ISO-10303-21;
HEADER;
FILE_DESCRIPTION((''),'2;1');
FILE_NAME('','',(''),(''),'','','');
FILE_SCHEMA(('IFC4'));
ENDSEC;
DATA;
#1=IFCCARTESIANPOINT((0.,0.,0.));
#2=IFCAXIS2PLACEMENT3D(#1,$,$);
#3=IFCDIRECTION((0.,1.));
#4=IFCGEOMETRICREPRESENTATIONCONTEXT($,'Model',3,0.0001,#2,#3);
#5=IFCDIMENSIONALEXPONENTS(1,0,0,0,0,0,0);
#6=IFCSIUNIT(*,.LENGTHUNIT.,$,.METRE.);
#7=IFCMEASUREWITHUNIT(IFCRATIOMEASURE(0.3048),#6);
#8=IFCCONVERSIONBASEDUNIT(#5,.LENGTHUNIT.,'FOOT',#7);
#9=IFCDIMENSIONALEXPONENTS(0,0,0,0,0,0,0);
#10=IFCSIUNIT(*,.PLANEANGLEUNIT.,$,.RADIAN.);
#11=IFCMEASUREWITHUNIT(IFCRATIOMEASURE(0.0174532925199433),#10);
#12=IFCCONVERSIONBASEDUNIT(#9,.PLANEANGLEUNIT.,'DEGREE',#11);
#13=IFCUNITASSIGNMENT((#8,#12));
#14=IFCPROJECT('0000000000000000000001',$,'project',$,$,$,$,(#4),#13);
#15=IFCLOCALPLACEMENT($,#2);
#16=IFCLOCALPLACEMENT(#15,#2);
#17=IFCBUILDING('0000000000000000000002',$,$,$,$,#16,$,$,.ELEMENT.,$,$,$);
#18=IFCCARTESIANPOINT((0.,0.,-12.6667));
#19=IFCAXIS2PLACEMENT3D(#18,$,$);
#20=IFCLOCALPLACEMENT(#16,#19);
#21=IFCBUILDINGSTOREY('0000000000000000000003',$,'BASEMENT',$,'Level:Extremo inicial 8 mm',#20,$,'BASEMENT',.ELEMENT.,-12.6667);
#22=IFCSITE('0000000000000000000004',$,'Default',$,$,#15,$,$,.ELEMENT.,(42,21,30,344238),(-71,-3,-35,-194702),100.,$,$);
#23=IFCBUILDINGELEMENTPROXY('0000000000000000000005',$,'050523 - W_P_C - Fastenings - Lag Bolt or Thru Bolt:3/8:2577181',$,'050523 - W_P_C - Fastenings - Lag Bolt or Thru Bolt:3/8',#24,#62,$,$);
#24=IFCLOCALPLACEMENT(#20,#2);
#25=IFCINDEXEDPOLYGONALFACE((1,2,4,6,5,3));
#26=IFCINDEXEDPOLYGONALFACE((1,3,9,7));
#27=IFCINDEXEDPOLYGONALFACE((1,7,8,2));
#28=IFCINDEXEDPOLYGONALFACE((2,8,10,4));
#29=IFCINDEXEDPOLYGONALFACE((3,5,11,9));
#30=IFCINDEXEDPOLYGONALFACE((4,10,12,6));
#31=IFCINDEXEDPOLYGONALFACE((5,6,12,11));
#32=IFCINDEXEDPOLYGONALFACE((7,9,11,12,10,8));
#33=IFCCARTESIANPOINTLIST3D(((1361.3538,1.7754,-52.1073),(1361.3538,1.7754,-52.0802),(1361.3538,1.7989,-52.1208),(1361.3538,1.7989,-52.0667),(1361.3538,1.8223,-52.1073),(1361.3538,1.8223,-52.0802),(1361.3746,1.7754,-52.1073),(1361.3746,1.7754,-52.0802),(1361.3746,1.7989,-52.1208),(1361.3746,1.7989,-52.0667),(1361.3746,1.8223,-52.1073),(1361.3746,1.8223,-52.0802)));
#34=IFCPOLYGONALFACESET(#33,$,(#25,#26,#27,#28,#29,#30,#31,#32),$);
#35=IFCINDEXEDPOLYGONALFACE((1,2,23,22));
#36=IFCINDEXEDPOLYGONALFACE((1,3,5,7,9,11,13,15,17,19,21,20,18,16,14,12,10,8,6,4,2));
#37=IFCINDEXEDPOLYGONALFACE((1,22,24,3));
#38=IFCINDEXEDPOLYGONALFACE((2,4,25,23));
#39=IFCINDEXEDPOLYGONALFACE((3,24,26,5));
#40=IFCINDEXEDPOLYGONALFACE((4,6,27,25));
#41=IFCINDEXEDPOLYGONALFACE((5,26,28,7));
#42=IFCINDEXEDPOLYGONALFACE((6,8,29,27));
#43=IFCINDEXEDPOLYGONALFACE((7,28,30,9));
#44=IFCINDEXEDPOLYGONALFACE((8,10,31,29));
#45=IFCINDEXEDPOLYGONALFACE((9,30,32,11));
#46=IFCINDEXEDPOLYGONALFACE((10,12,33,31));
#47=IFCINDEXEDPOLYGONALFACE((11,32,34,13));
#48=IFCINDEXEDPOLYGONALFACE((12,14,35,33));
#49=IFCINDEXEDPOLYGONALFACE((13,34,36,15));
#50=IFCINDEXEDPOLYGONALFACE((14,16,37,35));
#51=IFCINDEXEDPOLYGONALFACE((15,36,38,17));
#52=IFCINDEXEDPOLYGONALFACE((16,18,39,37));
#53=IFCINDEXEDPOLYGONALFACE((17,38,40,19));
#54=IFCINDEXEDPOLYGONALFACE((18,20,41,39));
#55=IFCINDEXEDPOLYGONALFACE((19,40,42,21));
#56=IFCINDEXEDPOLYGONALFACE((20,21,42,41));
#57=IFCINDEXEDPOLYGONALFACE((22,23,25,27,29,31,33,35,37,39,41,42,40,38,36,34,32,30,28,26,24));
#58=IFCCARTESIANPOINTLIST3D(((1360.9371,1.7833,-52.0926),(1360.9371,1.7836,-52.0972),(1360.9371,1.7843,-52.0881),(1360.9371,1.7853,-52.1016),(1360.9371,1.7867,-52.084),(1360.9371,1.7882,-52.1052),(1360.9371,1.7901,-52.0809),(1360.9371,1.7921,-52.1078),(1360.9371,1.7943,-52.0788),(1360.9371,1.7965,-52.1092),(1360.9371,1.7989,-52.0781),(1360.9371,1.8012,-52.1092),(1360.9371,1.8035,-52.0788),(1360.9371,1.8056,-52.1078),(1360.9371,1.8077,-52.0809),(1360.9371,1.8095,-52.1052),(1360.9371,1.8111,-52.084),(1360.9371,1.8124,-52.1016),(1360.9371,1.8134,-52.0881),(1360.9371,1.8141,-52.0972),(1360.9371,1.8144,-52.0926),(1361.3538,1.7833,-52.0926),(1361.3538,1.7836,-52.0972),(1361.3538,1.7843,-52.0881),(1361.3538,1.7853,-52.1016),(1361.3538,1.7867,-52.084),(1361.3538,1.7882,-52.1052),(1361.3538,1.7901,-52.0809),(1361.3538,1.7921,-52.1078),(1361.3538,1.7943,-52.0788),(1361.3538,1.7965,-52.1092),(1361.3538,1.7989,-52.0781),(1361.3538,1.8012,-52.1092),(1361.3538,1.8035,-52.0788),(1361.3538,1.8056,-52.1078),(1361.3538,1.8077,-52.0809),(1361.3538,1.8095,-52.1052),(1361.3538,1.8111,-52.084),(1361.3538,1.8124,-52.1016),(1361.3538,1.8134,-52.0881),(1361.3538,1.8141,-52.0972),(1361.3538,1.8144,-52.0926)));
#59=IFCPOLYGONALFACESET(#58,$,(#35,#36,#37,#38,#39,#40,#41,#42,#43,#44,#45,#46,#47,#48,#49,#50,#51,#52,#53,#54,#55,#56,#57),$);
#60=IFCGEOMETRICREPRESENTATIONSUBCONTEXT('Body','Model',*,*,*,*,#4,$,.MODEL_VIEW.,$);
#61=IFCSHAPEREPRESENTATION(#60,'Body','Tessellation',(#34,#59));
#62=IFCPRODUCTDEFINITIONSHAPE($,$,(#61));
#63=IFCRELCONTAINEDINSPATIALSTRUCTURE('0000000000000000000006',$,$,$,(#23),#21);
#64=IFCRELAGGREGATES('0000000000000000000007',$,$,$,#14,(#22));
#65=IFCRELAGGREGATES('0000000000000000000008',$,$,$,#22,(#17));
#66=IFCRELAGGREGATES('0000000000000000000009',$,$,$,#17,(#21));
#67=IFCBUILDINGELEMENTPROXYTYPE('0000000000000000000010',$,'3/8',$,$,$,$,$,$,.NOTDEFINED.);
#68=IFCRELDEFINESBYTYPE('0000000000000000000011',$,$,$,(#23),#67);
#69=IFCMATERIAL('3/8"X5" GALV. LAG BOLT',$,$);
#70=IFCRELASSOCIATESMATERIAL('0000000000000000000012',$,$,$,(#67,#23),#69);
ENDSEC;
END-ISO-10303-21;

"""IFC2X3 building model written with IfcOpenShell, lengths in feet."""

from ifc_helpers import new_model, entity, si_unit, converted_unit, direction, frame, frame_2d, origin, place, context, subcontext, project, spatial, polyline, circle, outline, extrude, source, transform, mapped, material, type_object, type_shapes, element, save


model = new_model("IFC2X3")

# Units and contexts
model_context = context("Model", 3, precision=0.0001, world=origin(), true_north=direction((0.0, 1.0)))
body_context = subcontext(model_context, "Body", "Model", "MODEL_VIEW")
ifc_project = project(units=[converted_unit("LENGTHUNIT", "FOOT", entity("IfcRatioMeasure", 0.3048), si_unit("LENGTHUNIT", "METRE"), dimensions=[1, 0, 0, 0, 0, 0, 0]), converted_unit("PLANEANGLEUNIT", "DEGREE", entity("IfcRatioMeasure", 0.0174532925199433), si_unit("PLANEANGLEUNIT", "RADIAN"), dimensions=[0, 0, 0, 0, 0, 0, 0])], contexts=[model_context])

# Site, building, storey
site_placement = place(None, origin())
site = spatial("IfcSite", under=ifc_project, at=site_placement, Name="Default", CompositionType="ELEMENT", RefLatitude=(42, 21, 30, 344238), RefLongitude=(-71, -3, -35, -194702), RefElevation=100.0)
building_placement = place(site_placement, origin())
building = spatial("IfcBuilding", under=site, at=building_placement, CompositionType="ELEMENT")
storey_placement = place(building_placement, frame((0.0, 0.0, -12.6667)))
storey = spatial("IfcBuildingStorey", under=building, at=storey_placement, Name="BASEMENT", ObjectType="Level:Extremo inicial 8 mm", LongName="BASEMENT", CompositionType="ELEMENT", Elevation=-12.6667)

# Building element proxy
ifc_material_1 = material(Name="3/8\"X5\" GALV. LAG BOLT")
building_element_proxy_type_1 = type_object("IfcBuildingElementProxyType", Name="3/8", PredefinedType="NOTDEFINED", material=ifc_material_1)
shared_shape_1 = source(origin(), body_context, "Body", "SweptSolid", [
    extrude(outline(polyline([(-0.0135, -0.0234), (0.0135, -0.0234), (0.0271, 0.0), (0.0135, 0.0234), (-0.0135, 0.0234), (-0.0271, 0.0), (-0.0135, -0.0234)])), frame((0.0, 0.0, 0.0), z_axis=(0.0, 0.0, 1.0), x_axis=(0.0, -1.0, 0.0)), (0.0, 0.0, 1.0), 0.0208),
    extrude(circle(Radius=0.0156, at=frame_2d((0.0, 0.0), x_axis=(1.0, 0.0))), frame((0.0, 0.0, -0.4167), z_axis=(0.0, 0.0, 1.0), x_axis=(0.0, 1.0, 0.0)), (0.0, 0.0, 1.0), 0.4167),
])
type_shapes(building_element_proxy_type_1, [shared_shape_1])
for number, where, z_axis, x_axis, name in (
    (1, (1361.3538, 1.7989, -52.0938), (1.0, 0.0, 0.0), (0.0, 1.0, 0.0), "050523 - W_P_C - Fastenings - Lag Bolt or Thru Bolt:3/8:2577181"),
):
    element("IfcBuildingElementProxy", number, at=place(storey_placement, frame(where, z_axis=z_axis, x_axis=x_axis)), inside=storey, type_object=building_element_proxy_type_1, material=ifc_material_1, Name=name, ObjectType="050523 - W_P_C - Fastenings - Lag Bolt or Thru Bolt:3/8", context=body_context, shape_type="MappedRepresentation", body=[
        mapped(shared_shape_1, transform((0.0, 0.0, 0.0), scale=1.0)),
    ])

save(model, "model.ifc")
